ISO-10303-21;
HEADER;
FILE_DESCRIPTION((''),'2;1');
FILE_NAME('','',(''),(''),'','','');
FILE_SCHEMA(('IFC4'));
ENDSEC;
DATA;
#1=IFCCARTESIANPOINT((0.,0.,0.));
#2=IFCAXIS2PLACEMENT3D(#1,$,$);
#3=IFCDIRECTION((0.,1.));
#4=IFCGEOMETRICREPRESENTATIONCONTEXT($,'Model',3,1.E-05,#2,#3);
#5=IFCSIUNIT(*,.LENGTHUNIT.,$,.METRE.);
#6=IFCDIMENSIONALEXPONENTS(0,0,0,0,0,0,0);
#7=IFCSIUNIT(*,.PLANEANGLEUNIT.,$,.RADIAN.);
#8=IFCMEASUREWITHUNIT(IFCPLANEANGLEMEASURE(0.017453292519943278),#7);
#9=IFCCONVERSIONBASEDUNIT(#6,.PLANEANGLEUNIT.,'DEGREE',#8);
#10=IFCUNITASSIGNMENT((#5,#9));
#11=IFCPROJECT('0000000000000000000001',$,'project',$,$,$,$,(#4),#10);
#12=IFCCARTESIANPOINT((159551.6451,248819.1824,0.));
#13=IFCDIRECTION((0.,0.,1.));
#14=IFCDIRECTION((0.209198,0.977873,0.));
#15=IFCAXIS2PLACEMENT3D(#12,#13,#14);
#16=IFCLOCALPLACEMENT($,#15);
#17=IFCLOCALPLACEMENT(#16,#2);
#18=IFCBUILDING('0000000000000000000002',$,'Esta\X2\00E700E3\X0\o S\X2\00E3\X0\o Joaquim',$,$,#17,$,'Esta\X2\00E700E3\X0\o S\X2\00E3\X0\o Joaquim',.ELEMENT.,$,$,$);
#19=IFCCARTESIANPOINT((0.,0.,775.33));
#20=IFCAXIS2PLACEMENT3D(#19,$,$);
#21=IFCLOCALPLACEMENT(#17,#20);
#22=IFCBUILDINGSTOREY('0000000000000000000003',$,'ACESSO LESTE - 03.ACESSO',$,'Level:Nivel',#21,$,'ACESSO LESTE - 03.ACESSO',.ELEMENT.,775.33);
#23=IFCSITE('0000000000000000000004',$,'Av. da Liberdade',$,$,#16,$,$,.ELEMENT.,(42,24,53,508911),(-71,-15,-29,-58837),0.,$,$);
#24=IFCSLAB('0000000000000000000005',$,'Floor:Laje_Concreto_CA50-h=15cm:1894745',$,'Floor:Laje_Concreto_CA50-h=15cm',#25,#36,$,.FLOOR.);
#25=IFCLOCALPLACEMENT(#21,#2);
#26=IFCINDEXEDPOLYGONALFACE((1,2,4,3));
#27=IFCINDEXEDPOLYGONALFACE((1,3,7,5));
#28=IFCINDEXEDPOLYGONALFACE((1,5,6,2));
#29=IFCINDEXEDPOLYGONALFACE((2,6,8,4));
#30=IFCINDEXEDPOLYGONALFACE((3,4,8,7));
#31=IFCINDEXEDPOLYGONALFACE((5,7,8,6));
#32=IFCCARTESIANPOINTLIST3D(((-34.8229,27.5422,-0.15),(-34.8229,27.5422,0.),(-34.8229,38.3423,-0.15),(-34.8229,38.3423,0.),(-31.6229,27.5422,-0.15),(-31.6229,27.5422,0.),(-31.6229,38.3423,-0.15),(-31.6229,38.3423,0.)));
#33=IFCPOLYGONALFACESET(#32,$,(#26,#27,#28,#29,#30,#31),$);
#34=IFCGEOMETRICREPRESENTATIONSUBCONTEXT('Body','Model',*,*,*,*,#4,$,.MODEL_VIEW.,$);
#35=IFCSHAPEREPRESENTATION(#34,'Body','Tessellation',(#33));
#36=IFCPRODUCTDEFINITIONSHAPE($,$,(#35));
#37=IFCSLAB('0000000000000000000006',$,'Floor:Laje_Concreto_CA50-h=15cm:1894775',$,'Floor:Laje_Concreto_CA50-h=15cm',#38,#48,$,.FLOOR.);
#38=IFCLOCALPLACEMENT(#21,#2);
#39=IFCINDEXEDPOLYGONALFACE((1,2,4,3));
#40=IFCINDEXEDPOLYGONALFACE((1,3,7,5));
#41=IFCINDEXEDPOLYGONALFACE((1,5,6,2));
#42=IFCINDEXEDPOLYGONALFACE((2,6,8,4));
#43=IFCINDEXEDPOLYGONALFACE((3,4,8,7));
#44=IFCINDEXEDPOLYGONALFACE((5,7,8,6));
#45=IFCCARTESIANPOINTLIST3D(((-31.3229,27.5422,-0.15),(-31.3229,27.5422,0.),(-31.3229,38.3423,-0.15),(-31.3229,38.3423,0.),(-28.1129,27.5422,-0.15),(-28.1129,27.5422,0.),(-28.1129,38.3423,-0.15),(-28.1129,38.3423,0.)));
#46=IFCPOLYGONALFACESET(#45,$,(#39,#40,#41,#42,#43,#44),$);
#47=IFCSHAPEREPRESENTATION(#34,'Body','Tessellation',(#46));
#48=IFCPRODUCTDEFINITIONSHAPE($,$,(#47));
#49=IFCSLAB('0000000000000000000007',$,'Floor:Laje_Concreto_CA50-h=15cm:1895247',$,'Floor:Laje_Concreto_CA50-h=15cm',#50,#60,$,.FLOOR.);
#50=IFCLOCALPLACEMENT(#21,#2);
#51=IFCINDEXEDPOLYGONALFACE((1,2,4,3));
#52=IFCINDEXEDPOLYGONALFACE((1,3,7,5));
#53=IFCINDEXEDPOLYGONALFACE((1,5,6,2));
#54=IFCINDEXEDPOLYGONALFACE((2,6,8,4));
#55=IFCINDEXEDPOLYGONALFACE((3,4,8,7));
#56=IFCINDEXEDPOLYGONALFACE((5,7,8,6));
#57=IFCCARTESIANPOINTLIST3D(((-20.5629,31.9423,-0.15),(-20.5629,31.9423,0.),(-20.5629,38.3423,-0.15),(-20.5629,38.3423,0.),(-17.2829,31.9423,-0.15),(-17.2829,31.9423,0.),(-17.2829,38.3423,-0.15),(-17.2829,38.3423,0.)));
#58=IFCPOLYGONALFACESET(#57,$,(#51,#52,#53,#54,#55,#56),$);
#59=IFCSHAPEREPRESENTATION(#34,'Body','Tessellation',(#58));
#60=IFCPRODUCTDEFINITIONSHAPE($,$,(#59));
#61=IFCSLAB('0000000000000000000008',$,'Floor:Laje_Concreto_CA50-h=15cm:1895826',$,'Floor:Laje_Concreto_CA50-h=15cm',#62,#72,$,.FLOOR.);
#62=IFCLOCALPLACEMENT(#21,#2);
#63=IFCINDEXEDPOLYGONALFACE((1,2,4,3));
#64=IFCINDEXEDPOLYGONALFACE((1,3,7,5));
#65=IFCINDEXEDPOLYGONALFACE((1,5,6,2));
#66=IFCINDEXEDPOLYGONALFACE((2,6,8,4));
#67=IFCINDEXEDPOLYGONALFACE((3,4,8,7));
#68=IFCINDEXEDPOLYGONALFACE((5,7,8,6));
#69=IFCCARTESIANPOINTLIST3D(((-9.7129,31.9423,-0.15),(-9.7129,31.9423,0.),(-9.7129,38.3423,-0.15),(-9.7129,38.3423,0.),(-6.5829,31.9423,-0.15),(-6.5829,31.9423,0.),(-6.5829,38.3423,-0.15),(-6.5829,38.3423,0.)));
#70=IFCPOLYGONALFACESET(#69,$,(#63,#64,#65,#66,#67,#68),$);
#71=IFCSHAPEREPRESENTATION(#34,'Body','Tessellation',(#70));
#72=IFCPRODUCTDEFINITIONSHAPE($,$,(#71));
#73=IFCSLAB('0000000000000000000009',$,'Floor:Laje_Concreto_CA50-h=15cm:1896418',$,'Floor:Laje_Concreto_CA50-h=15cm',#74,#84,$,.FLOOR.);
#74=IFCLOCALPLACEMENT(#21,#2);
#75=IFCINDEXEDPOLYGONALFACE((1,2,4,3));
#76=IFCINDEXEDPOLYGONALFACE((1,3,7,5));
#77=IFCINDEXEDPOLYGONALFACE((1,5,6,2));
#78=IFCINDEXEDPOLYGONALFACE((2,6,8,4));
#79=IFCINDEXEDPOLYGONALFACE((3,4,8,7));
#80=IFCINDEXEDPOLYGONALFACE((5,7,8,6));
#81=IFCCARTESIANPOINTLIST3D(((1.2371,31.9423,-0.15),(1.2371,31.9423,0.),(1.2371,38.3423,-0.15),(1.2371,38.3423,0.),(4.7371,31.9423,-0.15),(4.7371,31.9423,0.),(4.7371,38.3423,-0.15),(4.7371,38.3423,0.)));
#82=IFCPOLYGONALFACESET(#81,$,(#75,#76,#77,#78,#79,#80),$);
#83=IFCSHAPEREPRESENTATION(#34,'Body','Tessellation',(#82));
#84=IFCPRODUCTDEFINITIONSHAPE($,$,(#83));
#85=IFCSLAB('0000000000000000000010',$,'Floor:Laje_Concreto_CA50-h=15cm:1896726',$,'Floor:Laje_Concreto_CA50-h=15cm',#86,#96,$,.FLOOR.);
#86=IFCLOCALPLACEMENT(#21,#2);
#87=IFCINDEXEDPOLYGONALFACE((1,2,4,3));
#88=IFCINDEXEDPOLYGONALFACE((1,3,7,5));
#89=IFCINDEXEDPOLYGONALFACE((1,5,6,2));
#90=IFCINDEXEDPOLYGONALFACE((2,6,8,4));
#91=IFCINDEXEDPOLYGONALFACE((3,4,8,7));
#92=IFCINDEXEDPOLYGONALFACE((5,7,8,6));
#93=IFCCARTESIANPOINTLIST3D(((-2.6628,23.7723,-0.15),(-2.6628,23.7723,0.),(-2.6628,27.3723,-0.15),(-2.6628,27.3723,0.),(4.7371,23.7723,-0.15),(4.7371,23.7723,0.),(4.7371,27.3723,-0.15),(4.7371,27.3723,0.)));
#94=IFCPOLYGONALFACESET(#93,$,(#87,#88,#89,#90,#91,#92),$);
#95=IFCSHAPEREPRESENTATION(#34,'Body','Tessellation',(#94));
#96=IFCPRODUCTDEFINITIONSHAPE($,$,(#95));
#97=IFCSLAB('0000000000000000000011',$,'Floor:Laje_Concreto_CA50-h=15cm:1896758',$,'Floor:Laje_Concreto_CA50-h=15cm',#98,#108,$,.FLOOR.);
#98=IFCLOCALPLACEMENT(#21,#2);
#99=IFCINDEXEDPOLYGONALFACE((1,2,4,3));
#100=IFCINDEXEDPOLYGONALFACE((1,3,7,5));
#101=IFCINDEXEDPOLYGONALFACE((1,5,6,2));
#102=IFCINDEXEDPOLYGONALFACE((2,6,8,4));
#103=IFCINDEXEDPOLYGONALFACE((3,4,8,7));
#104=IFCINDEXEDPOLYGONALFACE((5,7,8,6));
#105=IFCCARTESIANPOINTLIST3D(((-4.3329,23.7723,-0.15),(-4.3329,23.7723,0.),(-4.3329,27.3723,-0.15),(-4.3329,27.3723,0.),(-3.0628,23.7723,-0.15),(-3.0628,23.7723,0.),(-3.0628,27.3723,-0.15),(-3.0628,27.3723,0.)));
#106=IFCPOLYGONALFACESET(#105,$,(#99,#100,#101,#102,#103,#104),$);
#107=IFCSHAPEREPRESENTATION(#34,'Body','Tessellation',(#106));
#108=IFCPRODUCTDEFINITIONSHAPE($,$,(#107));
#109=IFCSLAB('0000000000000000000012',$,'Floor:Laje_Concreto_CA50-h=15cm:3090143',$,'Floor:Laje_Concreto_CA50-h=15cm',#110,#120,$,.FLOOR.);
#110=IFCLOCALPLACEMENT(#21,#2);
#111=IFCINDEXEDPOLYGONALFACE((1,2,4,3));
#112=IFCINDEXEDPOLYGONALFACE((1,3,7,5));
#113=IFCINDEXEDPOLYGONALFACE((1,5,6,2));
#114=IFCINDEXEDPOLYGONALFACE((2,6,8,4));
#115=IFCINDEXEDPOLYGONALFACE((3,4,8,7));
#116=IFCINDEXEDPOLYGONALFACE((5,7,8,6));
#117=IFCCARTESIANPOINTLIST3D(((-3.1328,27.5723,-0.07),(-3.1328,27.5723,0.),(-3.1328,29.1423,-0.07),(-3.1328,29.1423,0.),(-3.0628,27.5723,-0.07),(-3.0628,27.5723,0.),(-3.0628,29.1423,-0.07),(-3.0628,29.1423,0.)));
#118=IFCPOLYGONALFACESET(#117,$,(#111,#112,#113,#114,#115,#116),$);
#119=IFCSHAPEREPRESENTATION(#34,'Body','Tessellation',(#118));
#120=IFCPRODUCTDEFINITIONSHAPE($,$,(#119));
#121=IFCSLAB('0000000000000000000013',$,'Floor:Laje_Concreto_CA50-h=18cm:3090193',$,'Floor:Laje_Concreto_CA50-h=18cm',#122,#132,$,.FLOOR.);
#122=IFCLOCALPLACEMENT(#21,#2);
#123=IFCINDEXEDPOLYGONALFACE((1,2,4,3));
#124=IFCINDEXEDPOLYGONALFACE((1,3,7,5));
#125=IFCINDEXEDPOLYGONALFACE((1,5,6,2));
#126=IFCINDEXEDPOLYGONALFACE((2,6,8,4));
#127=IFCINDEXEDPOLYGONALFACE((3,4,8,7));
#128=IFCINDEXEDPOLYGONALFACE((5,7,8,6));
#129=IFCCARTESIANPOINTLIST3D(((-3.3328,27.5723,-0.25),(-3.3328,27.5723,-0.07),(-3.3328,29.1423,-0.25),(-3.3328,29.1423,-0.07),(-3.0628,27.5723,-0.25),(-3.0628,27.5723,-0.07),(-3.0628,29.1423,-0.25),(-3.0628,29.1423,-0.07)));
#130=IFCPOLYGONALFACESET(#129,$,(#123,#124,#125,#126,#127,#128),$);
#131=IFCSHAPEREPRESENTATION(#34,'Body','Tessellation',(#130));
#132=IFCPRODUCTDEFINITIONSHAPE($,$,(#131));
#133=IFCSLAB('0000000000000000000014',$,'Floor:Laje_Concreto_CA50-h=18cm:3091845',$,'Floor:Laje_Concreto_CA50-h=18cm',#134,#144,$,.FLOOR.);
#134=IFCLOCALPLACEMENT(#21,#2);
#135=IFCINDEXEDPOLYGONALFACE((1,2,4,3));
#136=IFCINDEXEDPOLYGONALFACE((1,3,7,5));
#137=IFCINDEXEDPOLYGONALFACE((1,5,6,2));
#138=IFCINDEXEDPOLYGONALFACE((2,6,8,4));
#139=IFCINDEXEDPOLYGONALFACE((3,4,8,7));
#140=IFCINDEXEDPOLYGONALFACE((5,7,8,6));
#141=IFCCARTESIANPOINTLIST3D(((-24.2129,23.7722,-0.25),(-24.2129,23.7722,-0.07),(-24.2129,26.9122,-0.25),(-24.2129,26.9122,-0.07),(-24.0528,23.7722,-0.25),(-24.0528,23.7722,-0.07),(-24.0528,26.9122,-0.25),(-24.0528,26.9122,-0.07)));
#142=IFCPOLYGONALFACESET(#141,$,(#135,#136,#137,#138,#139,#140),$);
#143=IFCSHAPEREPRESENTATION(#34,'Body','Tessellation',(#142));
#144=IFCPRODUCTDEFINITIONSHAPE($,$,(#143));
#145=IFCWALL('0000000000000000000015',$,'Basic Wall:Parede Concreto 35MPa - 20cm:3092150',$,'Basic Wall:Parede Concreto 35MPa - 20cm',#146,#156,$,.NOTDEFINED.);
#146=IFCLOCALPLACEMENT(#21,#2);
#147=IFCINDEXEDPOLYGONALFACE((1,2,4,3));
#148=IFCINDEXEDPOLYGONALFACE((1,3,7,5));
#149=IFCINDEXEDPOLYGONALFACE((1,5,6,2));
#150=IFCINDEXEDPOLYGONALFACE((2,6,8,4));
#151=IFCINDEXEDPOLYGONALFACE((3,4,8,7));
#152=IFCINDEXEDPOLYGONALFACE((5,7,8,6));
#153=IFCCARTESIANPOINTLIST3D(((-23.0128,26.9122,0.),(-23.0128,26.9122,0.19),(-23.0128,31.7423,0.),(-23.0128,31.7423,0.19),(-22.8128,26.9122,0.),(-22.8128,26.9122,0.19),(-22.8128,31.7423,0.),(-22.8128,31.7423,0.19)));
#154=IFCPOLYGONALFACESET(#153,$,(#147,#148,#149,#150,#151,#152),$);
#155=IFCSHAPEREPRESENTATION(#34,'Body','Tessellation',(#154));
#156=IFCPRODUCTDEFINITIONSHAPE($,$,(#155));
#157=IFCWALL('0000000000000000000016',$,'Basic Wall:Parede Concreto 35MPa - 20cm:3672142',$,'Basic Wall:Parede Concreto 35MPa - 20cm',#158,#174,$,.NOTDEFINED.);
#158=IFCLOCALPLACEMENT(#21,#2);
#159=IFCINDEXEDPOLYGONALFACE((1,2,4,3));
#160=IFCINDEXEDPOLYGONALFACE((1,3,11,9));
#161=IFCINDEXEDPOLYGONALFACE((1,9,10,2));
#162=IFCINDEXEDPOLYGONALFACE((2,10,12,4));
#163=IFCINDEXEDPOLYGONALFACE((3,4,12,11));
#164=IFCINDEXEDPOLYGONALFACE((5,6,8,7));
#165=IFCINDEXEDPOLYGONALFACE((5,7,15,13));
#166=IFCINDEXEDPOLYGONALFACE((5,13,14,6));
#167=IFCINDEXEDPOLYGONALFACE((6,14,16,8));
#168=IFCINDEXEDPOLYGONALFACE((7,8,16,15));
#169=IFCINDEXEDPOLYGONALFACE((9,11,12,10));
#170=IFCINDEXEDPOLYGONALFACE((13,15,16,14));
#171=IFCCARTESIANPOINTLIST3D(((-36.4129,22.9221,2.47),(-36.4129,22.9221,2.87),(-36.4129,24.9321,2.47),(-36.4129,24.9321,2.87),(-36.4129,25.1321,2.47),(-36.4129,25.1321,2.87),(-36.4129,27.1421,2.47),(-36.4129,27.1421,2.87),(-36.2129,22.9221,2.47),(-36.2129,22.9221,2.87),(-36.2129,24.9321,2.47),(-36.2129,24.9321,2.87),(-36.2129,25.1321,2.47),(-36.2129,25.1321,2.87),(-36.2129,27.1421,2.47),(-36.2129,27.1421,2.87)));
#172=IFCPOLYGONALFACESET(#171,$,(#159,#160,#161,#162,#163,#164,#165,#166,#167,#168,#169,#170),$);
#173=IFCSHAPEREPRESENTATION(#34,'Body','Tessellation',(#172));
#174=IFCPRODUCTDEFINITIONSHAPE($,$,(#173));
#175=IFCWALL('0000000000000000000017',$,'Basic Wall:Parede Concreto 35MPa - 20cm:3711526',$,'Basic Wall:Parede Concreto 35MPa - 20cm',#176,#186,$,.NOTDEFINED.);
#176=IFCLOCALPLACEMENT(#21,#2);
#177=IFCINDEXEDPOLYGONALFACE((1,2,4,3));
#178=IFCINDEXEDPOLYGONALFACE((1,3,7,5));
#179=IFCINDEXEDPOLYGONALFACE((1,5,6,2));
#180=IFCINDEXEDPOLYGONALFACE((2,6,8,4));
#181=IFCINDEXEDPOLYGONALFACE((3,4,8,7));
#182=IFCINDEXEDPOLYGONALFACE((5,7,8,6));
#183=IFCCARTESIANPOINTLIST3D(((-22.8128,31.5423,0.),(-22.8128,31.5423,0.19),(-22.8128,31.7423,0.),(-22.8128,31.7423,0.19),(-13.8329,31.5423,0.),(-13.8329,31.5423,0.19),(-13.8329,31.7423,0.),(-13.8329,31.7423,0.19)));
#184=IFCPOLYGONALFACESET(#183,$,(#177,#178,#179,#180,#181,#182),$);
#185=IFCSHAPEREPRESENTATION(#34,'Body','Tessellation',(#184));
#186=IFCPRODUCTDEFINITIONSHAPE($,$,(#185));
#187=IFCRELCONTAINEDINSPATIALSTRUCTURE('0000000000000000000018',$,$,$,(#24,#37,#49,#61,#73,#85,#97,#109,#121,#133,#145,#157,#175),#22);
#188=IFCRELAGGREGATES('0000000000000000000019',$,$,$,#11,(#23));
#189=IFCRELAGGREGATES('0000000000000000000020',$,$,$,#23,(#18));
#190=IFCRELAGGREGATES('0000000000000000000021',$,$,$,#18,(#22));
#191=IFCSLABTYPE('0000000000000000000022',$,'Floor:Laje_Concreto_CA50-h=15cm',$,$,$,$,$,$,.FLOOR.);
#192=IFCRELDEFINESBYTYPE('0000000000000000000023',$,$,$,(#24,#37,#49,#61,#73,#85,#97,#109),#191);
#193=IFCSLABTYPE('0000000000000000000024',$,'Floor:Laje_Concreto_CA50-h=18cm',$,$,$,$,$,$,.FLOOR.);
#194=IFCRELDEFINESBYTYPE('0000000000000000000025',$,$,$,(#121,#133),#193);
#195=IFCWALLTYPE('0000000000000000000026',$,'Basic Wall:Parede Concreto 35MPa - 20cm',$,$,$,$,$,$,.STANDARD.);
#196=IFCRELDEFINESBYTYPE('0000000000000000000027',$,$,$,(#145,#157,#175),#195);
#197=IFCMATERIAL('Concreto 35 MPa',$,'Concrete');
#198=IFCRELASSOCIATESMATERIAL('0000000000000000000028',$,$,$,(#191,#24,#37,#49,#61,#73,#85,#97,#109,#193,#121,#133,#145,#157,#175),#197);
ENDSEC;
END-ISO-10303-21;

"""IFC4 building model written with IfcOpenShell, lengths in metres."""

from ifc_helpers import new_model, entity, si_unit, converted_unit, direction, frame, origin, place, context, subcontext, project, spatial, indexed_curve, outline, extrude, material, type_object, element, save


model = new_model("IFC4")

# Units and contexts
model_context = context("Model", 3, precision=1e-05, world=origin(), true_north=direction((0.0, 1.0)))
body_context = subcontext(model_context, "Body", "Model", "MODEL_VIEW")
ifc_project = project(units=[si_unit("LENGTHUNIT", "METRE"), converted_unit("PLANEANGLEUNIT", "DEGREE", entity("IfcPlaneAngleMeasure", 0.017453292519943278), si_unit("PLANEANGLEUNIT", "RADIAN"), dimensions=[0, 0, 0, 0, 0, 0, 0])], contexts=[model_context])

# Site, building, storey
site_placement = place(None, frame((159551.6451, 248819.1824, 0.0), z_axis=(0.0, 0.0, 1.0), x_axis=(0.209198, 0.977873, 0.0)))
site = spatial("IfcSite", under=ifc_project, at=site_placement, Name="Av. da Liberdade", CompositionType="ELEMENT", RefLatitude=(42, 24, 53, 508911), RefLongitude=(-71, -15, -29, -58837), RefElevation=0.0)
building_placement = place(site_placement, origin())
building = spatial("IfcBuilding", under=site, at=building_placement, Name="Estação São Joaquim", LongName="Estação São Joaquim", CompositionType="ELEMENT")
storey_placement = place(building_placement, frame((0.0, 0.0, 775.33)))
storey = spatial("IfcBuildingStorey", under=building, at=storey_placement, Name="ACESSO LESTE - 03.ACESSO", ObjectType="Level:Nivel", LongName="ACESSO LESTE - 03.ACESSO", CompositionType="ELEMENT", Elevation=775.33)

# Slabs
ifc_material = material(Name="Concreto 35 MPa", Category="Concrete")
slab_type_1 = type_object("IfcSlabType", Name="Floor:Laje_Concreto_CA50-h=15cm", PredefinedType="FLOOR", material=ifc_material)
slab_1_placement = place(storey_placement, origin())
element("IfcSlab", 1, at=slab_1_placement, inside=storey, type_object=slab_type_1, material=ifc_material, Name="Floor:Laje_Concreto_CA50-h=15cm:1894745", ObjectType="Floor:Laje_Concreto_CA50-h=15cm", PredefinedType="FLOOR", context=body_context, shape_type="SweptSolid", body=[
    extrude(outline(indexed_curve([(-5.4, -1.6), (5.4, -1.6), (5.4, 1.6), (-5.4, 1.6), (-5.4, -1.6)], self_intersect=False)), frame((-33.2229, 32.9422, 0.0), z_axis=(0.0, 0.0, -1.0), x_axis=(0.0, 1.0, 0.0)), (0.0, 0.0, 1.0), 0.15),
])
slab_2_placement = place(storey_placement, origin())
element("IfcSlab", 2, at=slab_2_placement, inside=storey, type_object=slab_type_1, material=ifc_material, Name="Floor:Laje_Concreto_CA50-h=15cm:1894775", ObjectType="Floor:Laje_Concreto_CA50-h=15cm", PredefinedType="FLOOR", context=body_context, shape_type="SweptSolid", body=[
    extrude(outline(indexed_curve([(-5.4, -1.605), (5.4, -1.605), (5.4, 1.605), (-5.4, 1.605), (-5.4, -1.605)], self_intersect=False)), frame((-29.7179, 32.9422, 0.0), z_axis=(0.0, 0.0, -1.0), x_axis=(0.0, 1.0, 0.0)), (0.0, 0.0, 1.0), 0.15),
])
slab_3_placement = place(storey_placement, origin())
element("IfcSlab", 3, at=slab_3_placement, inside=storey, type_object=slab_type_1, material=ifc_material, Name="Floor:Laje_Concreto_CA50-h=15cm:1895247", ObjectType="Floor:Laje_Concreto_CA50-h=15cm", PredefinedType="FLOOR", context=body_context, shape_type="SweptSolid", body=[
    extrude(outline(indexed_curve([(-3.2, -1.64), (3.2, -1.64), (3.2, 1.64), (-3.2, 1.64), (-3.2, -1.64)], self_intersect=False)), frame((-18.9229, 35.1423, 0.0), z_axis=(0.0, 0.0, -1.0), x_axis=(0.0, 1.0, 0.0)), (0.0, 0.0, 1.0), 0.15),
])
slab_4_placement = place(storey_placement, origin())
element("IfcSlab", 4, at=slab_4_placement, inside=storey, type_object=slab_type_1, material=ifc_material, Name="Floor:Laje_Concreto_CA50-h=15cm:1895826", ObjectType="Floor:Laje_Concreto_CA50-h=15cm", PredefinedType="FLOOR", context=body_context, shape_type="SweptSolid", body=[
    extrude(outline(indexed_curve([(-3.2, -1.565), (3.2, -1.565), (3.2, 1.565), (-3.2, 1.565), (-3.2, -1.565)], self_intersect=False)), frame((-8.1479, 35.1423, 0.0), z_axis=(0.0, 0.0, -1.0), x_axis=(0.0, 1.0, 0.0)), (0.0, 0.0, 1.0), 0.15),
])
slab_5_placement = place(storey_placement, origin())
element("IfcSlab", 5, at=slab_5_placement, inside=storey, type_object=slab_type_1, material=ifc_material, Name="Floor:Laje_Concreto_CA50-h=15cm:1896418", ObjectType="Floor:Laje_Concreto_CA50-h=15cm", PredefinedType="FLOOR", context=body_context, shape_type="SweptSolid", body=[
    extrude(outline(indexed_curve([(-3.2, -1.75), (3.2, -1.75), (3.2, 1.75), (-3.2, 1.75), (-3.2, -1.75)], self_intersect=False)), frame((2.9871, 35.1423, 0.0), z_axis=(0.0, 0.0, -1.0), x_axis=(0.0, 1.0, 0.0)), (0.0, 0.0, 1.0), 0.15),
])
slab_6_placement = place(storey_placement, origin())
element("IfcSlab", 6, at=slab_6_placement, inside=storey, type_object=slab_type_1, material=ifc_material, Name="Floor:Laje_Concreto_CA50-h=15cm:1896726", ObjectType="Floor:Laje_Concreto_CA50-h=15cm", PredefinedType="FLOOR", context=body_context, shape_type="SweptSolid", body=[
    extrude(outline(indexed_curve([(-1.8, -3.7), (1.8, -3.7), (1.8, 3.7), (-1.8, 3.7), (-1.8, -3.7)], self_intersect=False)), frame((1.0372, 25.5723, 0.0), z_axis=(0.0, 0.0, -1.0), x_axis=(0.0, 1.0, 0.0)), (0.0, 0.0, 1.0), 0.15),
])
slab_7_placement = place(storey_placement, origin())
element("IfcSlab", 7, at=slab_7_placement, inside=storey, type_object=slab_type_1, material=ifc_material, Name="Floor:Laje_Concreto_CA50-h=15cm:1896758", ObjectType="Floor:Laje_Concreto_CA50-h=15cm", PredefinedType="FLOOR", context=body_context, shape_type="SweptSolid", body=[
    extrude(outline(indexed_curve([(-1.8, -0.635), (1.8, -0.635), (1.8, 0.635), (-1.8, 0.635), (-1.8, -0.635)], self_intersect=False)), frame((-3.6978, 25.5723, 0.0), z_axis=(0.0, 0.0, -1.0), x_axis=(0.0, 1.0, 0.0)), (0.0, 0.0, 1.0), 0.15),
])
slab_8_placement = place(storey_placement, origin())
element("IfcSlab", 8, at=slab_8_placement, inside=storey, type_object=slab_type_1, material=ifc_material, Name="Floor:Laje_Concreto_CA50-h=15cm:3090143", ObjectType="Floor:Laje_Concreto_CA50-h=15cm", PredefinedType="FLOOR", context=body_context, shape_type="SweptSolid", body=[
    extrude(outline(indexed_curve([(-0.785, -0.035), (0.785, -0.035), (0.785, 0.035), (-0.785, 0.035), (-0.785, -0.035)], self_intersect=False)), frame((-3.0978, 28.3573, 0.0), z_axis=(0.0, 0.0, -1.0), x_axis=(0.0, 1.0, 0.0)), (0.0, 0.0, 1.0), 0.07),
])
slab_type_2 = type_object("IfcSlabType", Name="Floor:Laje_Concreto_CA50-h=18cm", PredefinedType="FLOOR", material=ifc_material)
slab_9_placement = place(storey_placement, origin())
element("IfcSlab", 9, at=slab_9_placement, inside=storey, type_object=slab_type_2, material=ifc_material, Name="Floor:Laje_Concreto_CA50-h=18cm:3090193", ObjectType="Floor:Laje_Concreto_CA50-h=18cm", PredefinedType="FLOOR", context=body_context, shape_type="SweptSolid", body=[
    extrude(outline(indexed_curve([(-0.785, -0.135), (0.785, -0.135), (0.785, 0.135), (-0.785, 0.135), (-0.785, -0.135)], self_intersect=False)), frame((-3.1978, 28.3573, -0.07), z_axis=(0.0, 0.0, -1.0), x_axis=(0.0, 1.0, 0.0)), (0.0, 0.0, 1.0), 0.18),
])
slab_10_placement = place(storey_placement, origin())
element("IfcSlab", 10, at=slab_10_placement, inside=storey, type_object=slab_type_2, material=ifc_material, Name="Floor:Laje_Concreto_CA50-h=18cm:3091845", ObjectType="Floor:Laje_Concreto_CA50-h=18cm", PredefinedType="FLOOR", context=body_context, shape_type="SweptSolid", body=[
    extrude(outline(indexed_curve([(-1.57, -0.08), (1.57, -0.08), (1.57, 0.08), (-1.57, 0.08), (-1.57, -0.08)], self_intersect=False)), frame((-24.1328, 25.3422, -0.07), z_axis=(0.0, 0.0, -1.0), x_axis=(0.0, 1.0, 0.0)), (0.0, 0.0, 1.0), 0.18),
])

# Wall
wall_type = type_object("IfcWallType", Name="Basic Wall:Parede Concreto 35MPa - 20cm", PredefinedType="STANDARD")
wall_1_placement = place(storey_placement, frame((-22.9128, 31.7423, 0.0), z_axis=(0.0, 0.0, 1.0), x_axis=(0.0, -1.0, 0.0)))
element("IfcWall", 11, at=wall_1_placement, inside=storey, type_object=wall_type, material=ifc_material, Name="Basic Wall:Parede Concreto 35MPa - 20cm:3092150", ObjectType="Basic Wall:Parede Concreto 35MPa - 20cm", PredefinedType="NOTDEFINED", context=body_context, shape_type="SweptSolid", body=[
    extrude(outline(indexed_curve([(4.8301, 0.1), (0.0, 0.1), (0.0, -0.1), (4.8301, -0.1), (4.8301, 0.1)], self_intersect=False)), origin(), (0.0, 0.0, 1.0), 0.19),
])

# Wall, opening
wall_2_placement = place(storey_placement, frame((-36.3129, 27.1421, 2.47), z_axis=(0.0, 0.0, 1.0), x_axis=(0.0, -1.0, 0.0)))
wall_2 = element("IfcWall", 12, at=wall_2_placement, inside=storey, type_object=wall_type, material=ifc_material, Name="Basic Wall:Parede Concreto 35MPa - 20cm:3672142", ObjectType="Basic Wall:Parede Concreto 35MPa - 20cm", PredefinedType="NOTDEFINED", context=body_context, shape_type="SweptSolid", body=[
    extrude(outline(indexed_curve([(4.2201, 0.1), (0.0, 0.1), (0.0, -0.1), (4.2201, -0.1), (4.2201, 0.1)], self_intersect=False)), origin(), (0.0, 0.0, 1.0), 0.4),
])
opening_placement = place(storey_placement, frame((-36.3129, 27.1421, 2.47), z_axis=(0.0, 0.0, 1.0), x_axis=(0.0, -1.0, 0.0)))
element("IfcOpeningElement", 13, at=opening_placement, cuts=wall_2, PredefinedType="OPENING", context=body_context, shape_type="SweptSolid", body=[
    extrude(outline(indexed_curve([(-0.2, -0.1), (0.2, -0.1), (0.2, 0.1), (-0.2, 0.1), (-0.2, -0.1)], self_intersect=False)), frame((2.2101, 0.0, 0.2), z_axis=(-1.0, 0.0, 0.0), x_axis=(0.0, 0.0, 1.0)), (0.0, 0.0, 1.0), 0.2),
])

# Wall
wall_3_placement = place(storey_placement, frame((-22.8128, 31.6423, 0.0)))
element("IfcWall", 14, at=wall_3_placement, inside=storey, type_object=wall_type, material=ifc_material, Name="Basic Wall:Parede Concreto 35MPa - 20cm:3711526", ObjectType="Basic Wall:Parede Concreto 35MPa - 20cm", PredefinedType="NOTDEFINED", context=body_context, shape_type="SweptSolid", body=[
    extrude(outline(indexed_curve([(8.98, 0.1), (0.0, 0.1), (0.0, -0.1), (8.98, -0.1), (8.98, 0.1)], self_intersect=False)), origin(), (0.0, 0.0, 1.0), 0.19),
])

save(model, "model.ifc")
